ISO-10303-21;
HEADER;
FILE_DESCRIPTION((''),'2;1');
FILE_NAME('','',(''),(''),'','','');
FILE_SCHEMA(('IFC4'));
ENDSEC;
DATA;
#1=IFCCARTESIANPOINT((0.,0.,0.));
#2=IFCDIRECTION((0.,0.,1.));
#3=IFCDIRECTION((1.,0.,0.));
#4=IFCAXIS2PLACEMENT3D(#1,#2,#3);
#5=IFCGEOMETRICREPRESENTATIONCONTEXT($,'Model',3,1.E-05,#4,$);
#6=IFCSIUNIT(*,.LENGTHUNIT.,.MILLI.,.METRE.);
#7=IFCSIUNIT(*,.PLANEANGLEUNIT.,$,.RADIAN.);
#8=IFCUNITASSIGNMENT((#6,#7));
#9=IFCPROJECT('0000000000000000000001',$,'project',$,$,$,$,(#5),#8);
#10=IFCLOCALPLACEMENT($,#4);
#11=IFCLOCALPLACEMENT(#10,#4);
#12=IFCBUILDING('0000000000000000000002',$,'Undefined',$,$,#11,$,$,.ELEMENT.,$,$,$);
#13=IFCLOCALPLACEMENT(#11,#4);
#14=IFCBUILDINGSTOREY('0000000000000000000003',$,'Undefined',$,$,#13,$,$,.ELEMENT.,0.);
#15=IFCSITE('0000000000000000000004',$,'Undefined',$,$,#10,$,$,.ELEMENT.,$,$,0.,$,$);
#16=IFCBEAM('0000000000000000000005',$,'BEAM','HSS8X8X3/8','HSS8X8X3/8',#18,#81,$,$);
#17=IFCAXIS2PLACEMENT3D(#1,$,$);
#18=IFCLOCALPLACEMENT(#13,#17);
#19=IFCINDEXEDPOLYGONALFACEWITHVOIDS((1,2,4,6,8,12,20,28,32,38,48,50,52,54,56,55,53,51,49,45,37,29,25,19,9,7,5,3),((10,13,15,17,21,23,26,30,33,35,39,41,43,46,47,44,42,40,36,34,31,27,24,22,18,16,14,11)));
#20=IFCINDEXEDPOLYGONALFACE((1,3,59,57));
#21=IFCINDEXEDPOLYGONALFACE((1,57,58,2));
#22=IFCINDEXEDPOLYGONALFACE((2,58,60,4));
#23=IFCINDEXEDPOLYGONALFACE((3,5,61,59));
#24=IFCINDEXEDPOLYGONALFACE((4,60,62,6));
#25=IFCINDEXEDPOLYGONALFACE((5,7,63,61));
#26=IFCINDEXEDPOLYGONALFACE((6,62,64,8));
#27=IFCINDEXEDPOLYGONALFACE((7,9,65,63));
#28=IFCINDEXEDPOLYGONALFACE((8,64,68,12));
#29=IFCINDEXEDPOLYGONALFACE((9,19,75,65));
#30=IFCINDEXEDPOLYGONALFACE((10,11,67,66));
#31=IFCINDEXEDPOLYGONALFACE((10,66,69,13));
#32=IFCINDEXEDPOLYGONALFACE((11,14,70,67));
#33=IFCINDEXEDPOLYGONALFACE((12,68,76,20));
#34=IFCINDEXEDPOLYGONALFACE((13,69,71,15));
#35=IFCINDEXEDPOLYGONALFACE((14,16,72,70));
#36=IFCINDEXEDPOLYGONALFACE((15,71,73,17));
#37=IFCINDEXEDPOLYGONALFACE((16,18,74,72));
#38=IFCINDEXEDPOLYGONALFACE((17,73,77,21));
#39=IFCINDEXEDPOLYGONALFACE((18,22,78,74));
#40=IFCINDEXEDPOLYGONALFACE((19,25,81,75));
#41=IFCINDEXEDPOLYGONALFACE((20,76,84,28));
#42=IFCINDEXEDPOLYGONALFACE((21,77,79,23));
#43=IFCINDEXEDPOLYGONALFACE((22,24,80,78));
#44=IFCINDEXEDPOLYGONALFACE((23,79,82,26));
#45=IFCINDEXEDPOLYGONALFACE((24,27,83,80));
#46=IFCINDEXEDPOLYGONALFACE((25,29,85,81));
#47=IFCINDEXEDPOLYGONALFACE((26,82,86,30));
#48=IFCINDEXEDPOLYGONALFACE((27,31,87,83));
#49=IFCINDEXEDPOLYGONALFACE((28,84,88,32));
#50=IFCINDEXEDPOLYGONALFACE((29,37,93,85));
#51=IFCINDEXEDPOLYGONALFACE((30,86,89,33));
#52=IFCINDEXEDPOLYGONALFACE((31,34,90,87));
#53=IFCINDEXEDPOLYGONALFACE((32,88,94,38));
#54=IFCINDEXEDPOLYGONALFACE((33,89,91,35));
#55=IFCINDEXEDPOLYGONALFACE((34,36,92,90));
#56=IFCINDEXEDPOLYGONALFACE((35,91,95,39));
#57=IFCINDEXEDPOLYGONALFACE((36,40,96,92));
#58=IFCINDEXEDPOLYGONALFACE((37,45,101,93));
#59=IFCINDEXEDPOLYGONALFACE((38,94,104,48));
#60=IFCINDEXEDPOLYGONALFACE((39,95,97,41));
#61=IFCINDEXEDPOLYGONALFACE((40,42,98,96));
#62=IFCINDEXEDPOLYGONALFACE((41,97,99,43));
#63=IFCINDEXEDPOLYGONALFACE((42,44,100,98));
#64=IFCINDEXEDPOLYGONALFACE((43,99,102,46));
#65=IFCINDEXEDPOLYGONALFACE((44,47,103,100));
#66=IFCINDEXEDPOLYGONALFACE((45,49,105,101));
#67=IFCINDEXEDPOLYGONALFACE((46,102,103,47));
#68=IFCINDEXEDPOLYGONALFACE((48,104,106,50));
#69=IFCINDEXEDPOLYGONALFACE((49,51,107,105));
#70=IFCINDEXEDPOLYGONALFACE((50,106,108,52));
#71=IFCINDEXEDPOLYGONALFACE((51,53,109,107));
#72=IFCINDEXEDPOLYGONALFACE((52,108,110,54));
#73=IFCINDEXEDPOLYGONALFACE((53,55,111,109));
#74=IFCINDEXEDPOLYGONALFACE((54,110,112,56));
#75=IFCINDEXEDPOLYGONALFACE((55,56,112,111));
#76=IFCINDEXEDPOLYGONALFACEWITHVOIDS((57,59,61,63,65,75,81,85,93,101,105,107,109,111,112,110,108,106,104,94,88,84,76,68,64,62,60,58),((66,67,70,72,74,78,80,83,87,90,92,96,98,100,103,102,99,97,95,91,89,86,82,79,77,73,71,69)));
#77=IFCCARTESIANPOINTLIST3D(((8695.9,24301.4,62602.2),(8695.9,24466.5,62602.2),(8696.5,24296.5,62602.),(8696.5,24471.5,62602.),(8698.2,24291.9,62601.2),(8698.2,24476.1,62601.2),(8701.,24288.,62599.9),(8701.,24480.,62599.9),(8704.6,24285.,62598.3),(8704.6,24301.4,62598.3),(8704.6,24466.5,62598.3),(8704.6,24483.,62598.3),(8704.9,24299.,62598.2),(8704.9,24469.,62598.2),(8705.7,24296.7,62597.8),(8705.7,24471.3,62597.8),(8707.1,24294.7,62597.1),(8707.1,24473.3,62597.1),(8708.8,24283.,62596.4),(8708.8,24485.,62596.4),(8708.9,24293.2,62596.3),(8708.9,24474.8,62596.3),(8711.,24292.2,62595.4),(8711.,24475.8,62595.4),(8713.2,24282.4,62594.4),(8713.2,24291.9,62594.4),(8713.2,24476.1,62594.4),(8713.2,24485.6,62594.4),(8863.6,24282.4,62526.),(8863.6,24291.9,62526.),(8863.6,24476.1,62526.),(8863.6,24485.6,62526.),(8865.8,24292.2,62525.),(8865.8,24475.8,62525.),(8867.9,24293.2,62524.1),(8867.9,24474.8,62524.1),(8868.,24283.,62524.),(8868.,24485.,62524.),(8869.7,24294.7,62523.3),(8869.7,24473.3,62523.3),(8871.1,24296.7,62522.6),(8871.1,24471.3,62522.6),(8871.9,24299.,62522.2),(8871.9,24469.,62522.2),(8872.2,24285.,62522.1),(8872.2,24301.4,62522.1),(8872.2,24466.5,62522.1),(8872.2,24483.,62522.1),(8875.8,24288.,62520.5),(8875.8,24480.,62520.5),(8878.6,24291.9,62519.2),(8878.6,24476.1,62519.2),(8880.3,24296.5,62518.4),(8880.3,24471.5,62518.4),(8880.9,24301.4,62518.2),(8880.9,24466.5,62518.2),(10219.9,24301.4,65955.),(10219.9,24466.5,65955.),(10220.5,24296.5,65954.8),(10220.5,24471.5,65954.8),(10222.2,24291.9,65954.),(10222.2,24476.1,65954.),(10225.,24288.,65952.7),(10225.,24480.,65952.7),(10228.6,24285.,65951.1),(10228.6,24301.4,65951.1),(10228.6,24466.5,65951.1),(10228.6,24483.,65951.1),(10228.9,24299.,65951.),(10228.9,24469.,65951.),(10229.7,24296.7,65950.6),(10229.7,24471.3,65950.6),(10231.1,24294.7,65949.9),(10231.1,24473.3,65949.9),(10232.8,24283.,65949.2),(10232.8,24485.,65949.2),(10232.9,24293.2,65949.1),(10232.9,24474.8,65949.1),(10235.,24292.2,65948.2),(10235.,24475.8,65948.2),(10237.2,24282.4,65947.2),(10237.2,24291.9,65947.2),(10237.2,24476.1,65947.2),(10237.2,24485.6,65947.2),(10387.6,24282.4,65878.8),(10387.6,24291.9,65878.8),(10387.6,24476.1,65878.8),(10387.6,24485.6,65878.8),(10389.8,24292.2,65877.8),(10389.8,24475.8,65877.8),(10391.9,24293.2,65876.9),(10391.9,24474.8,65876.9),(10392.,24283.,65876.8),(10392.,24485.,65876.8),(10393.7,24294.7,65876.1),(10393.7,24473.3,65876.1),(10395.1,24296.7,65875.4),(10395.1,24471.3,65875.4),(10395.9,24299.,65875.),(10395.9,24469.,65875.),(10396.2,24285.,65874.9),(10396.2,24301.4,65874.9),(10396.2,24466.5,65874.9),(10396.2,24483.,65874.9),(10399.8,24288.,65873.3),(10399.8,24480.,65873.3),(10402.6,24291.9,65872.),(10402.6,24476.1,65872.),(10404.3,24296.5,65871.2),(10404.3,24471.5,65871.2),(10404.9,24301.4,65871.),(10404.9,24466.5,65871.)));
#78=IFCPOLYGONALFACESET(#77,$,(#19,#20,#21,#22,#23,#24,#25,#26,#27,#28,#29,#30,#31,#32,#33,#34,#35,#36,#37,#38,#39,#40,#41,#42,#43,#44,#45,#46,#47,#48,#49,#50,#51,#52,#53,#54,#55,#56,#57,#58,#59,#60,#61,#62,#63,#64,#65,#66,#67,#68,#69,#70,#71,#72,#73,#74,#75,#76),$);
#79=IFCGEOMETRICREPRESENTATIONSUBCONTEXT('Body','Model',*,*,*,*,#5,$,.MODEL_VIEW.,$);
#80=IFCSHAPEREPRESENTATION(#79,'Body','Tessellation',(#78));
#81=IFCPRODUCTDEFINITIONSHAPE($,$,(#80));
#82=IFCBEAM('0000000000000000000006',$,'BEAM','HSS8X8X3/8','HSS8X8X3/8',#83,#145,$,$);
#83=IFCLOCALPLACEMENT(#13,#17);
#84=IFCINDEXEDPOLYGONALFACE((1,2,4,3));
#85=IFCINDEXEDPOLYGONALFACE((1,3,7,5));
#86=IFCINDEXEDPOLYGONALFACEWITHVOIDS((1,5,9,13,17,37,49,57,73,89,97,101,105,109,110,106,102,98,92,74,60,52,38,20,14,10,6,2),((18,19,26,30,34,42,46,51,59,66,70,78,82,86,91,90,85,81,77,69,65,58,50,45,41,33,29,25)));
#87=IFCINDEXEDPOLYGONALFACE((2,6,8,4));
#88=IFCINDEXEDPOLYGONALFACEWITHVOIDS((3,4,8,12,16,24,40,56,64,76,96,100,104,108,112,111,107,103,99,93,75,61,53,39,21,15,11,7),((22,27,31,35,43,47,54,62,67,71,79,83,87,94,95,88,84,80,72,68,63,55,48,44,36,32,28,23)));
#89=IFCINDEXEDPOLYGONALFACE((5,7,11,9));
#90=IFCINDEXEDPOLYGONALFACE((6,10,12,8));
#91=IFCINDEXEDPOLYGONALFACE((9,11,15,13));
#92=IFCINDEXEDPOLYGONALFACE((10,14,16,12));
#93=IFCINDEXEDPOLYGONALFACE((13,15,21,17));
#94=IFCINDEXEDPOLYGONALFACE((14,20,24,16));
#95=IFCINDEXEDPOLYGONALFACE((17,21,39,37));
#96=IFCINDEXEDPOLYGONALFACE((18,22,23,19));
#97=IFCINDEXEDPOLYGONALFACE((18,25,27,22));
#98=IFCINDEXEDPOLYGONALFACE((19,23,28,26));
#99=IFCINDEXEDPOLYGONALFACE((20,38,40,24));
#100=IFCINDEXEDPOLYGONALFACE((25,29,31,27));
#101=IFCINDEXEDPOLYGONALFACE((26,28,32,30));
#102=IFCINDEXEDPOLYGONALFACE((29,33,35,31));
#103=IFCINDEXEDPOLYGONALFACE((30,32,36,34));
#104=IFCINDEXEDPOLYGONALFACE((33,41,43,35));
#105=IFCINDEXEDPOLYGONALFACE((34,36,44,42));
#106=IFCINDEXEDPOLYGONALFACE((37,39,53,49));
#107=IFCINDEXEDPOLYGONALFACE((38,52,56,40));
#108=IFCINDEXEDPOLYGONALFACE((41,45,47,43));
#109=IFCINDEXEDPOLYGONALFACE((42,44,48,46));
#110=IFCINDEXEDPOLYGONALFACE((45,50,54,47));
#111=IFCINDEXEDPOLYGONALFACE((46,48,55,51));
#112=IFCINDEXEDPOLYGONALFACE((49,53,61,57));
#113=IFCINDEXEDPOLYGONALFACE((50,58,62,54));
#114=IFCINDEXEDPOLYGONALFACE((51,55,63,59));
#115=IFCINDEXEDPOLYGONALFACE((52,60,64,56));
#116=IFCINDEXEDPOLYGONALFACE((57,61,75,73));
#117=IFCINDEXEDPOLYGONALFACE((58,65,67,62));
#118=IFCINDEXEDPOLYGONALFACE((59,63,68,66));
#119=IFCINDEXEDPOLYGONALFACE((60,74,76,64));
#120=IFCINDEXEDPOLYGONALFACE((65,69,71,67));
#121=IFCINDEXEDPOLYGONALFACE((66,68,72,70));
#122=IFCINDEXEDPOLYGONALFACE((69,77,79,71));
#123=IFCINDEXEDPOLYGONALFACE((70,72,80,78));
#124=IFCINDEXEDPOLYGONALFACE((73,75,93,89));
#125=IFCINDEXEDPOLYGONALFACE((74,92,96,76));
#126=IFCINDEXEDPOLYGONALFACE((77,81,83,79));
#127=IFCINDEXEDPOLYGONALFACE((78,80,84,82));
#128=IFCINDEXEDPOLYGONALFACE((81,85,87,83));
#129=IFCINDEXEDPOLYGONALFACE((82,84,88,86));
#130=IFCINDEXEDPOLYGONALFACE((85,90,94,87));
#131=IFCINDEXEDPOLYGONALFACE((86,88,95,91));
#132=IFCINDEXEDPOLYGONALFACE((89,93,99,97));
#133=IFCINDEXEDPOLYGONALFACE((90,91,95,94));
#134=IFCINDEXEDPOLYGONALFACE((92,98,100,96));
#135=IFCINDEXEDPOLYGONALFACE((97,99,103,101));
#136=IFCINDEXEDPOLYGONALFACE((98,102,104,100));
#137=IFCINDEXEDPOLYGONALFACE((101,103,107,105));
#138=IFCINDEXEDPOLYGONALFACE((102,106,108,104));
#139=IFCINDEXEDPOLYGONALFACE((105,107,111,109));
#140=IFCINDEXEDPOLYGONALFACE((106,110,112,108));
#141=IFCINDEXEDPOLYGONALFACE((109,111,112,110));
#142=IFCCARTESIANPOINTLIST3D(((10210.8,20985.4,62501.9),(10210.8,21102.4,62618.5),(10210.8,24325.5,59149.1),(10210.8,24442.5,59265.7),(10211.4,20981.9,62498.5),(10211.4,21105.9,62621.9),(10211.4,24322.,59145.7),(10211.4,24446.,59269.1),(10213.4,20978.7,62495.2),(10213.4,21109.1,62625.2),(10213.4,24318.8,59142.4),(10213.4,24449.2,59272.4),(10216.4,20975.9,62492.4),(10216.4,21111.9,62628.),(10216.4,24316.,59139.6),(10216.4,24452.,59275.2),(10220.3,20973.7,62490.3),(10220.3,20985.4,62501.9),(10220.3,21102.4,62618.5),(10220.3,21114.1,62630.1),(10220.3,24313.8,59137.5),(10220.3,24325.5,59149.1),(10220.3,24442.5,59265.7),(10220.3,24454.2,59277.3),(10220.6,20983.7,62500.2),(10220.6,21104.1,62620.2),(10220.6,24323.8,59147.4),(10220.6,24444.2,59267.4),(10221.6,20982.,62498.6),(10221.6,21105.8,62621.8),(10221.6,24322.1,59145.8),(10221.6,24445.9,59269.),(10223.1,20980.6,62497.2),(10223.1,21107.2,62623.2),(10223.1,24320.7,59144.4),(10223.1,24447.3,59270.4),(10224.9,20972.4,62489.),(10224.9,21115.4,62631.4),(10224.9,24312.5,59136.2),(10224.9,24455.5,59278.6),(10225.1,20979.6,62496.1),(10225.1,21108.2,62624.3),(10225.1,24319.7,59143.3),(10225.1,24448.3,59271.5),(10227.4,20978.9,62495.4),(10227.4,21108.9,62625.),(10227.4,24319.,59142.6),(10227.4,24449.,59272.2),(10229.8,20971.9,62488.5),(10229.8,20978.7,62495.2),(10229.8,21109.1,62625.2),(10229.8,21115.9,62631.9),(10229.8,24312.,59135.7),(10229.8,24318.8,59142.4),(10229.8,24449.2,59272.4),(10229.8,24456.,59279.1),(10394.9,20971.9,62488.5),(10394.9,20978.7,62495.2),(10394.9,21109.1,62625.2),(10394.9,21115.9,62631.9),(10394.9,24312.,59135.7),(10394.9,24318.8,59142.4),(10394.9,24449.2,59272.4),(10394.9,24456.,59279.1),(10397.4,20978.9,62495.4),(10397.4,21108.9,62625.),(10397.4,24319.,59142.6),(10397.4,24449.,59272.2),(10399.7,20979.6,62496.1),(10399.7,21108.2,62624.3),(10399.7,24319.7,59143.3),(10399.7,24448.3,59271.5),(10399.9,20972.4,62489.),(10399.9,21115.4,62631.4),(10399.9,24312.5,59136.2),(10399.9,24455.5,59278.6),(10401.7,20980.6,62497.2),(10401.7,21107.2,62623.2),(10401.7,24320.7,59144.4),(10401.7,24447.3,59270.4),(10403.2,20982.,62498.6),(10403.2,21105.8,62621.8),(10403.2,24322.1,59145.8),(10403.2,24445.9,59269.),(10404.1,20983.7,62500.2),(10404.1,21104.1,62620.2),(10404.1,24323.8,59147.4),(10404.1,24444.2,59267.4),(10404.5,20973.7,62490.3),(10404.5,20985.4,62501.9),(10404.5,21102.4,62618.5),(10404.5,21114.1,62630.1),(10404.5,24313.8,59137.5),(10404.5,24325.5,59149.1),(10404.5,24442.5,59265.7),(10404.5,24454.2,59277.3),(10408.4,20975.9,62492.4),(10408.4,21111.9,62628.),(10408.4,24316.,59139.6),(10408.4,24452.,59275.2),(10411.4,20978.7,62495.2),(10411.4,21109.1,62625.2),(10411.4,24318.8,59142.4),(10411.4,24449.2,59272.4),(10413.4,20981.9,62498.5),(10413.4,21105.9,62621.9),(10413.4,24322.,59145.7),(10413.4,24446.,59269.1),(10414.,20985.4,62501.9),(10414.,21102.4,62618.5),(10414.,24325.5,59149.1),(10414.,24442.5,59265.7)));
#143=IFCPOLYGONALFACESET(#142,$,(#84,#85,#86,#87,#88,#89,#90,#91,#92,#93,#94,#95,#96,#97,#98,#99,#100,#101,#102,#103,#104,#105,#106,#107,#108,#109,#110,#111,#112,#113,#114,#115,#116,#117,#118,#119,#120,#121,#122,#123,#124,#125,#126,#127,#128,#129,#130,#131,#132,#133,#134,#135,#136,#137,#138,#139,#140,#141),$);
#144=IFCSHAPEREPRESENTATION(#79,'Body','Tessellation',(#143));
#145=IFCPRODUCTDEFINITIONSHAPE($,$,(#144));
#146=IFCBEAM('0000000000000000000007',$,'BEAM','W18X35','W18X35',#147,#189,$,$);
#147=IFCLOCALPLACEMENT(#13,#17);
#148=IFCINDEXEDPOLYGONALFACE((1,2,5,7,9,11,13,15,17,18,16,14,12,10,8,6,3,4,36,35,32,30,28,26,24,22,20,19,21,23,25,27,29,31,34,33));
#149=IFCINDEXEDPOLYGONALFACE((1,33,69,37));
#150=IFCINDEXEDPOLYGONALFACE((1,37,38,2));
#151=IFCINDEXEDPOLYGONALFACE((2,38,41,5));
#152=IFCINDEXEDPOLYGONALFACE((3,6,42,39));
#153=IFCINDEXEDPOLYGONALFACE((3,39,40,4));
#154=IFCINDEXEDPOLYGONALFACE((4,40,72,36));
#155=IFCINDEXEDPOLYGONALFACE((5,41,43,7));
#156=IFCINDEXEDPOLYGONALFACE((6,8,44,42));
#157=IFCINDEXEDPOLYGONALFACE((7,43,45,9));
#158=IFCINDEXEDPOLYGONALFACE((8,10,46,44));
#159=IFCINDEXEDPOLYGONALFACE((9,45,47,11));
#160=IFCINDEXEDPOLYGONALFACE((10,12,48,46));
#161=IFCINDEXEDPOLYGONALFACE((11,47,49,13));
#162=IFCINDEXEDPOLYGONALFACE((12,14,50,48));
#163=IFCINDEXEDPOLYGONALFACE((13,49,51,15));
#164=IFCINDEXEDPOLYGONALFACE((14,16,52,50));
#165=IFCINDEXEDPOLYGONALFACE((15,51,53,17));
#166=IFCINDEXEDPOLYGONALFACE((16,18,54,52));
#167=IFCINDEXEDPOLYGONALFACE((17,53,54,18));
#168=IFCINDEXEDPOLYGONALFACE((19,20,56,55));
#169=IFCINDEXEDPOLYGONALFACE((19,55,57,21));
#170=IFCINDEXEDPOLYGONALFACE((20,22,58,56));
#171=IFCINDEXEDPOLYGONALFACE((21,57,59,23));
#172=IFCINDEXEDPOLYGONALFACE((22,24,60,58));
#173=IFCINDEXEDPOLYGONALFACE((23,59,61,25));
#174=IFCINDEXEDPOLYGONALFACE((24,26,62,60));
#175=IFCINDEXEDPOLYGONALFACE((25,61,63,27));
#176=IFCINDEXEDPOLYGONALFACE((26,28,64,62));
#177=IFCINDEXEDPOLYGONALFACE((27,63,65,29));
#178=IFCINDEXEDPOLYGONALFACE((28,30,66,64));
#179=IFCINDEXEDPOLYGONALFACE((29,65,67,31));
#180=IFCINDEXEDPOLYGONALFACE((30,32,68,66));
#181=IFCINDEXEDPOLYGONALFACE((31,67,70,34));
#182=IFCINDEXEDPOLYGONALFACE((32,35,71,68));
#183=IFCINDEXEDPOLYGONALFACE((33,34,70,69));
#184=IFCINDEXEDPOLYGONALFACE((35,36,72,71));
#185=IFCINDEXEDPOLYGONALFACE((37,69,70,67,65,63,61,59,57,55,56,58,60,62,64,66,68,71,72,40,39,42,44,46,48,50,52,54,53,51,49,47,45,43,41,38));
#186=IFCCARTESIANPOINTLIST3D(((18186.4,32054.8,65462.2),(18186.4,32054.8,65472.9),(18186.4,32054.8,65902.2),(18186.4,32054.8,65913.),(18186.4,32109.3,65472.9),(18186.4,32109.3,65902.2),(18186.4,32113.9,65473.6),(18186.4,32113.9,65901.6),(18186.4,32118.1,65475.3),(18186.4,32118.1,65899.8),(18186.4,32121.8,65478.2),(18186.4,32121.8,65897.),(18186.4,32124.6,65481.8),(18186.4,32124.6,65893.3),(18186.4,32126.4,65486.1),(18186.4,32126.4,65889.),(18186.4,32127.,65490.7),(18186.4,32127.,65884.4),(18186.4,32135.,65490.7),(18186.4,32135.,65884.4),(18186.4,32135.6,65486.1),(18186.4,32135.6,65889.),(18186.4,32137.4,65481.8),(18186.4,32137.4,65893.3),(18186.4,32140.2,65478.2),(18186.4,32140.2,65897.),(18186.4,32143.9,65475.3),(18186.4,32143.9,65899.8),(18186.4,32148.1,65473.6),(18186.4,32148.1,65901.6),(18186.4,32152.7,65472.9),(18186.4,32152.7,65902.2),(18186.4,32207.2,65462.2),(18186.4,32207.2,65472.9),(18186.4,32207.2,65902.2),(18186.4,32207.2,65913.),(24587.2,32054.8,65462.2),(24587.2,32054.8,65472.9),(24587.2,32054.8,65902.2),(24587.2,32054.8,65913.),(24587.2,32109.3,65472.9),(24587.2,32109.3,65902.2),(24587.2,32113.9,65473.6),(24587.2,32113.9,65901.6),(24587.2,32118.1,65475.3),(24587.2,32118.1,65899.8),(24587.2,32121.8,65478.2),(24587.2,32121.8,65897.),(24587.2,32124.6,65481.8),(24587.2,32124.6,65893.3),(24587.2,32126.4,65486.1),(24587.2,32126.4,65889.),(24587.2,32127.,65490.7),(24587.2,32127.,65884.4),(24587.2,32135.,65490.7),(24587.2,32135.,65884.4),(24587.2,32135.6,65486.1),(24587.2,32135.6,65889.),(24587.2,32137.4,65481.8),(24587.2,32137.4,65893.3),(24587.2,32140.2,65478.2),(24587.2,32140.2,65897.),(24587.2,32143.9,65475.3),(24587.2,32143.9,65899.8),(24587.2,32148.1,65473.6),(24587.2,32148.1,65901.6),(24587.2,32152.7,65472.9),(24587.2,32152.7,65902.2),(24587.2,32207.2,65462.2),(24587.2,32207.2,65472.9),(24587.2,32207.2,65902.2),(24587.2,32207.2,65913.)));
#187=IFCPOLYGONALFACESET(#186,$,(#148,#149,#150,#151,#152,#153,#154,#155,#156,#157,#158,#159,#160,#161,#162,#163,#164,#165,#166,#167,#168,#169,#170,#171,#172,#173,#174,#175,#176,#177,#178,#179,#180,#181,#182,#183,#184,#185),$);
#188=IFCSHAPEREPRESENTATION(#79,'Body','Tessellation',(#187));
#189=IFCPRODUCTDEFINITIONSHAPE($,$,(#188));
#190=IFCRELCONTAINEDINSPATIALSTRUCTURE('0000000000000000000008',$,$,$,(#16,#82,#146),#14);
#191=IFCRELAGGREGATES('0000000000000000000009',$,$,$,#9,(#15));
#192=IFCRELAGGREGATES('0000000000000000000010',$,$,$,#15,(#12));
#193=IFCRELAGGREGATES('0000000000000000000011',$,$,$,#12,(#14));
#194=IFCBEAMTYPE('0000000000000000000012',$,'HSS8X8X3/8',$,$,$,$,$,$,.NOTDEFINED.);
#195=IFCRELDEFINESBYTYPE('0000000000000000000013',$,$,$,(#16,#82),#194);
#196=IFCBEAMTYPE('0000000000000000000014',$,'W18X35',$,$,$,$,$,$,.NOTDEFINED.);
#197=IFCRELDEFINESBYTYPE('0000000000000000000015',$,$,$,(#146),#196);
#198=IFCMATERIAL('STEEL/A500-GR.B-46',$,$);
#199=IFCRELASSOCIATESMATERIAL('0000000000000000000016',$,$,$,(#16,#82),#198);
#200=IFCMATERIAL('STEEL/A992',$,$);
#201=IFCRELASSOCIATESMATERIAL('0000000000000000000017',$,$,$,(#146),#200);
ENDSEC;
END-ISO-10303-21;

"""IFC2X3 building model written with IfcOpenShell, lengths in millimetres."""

from ifc_helpers import new_model, si_unit, frame, origin_with_axes, origin_2d_with_axis, place, context, subcontext, project, spatial, hollow_rectangle, i_section, extrude, material, type_object, element, save


model = new_model("IFC2X3")

# Units and contexts
model_context = context("Model", 3, precision=1e-05, world=origin_with_axes())
body_context = subcontext(model_context, "Body", "Model", "MODEL_VIEW")
ifc_project = project(units=[si_unit("LENGTHUNIT", "METRE", prefix="MILLI"), si_unit("PLANEANGLEUNIT", "RADIAN")], contexts=[model_context])

# Site, building, storey
site_placement = place(None, origin_with_axes())
site = spatial("IfcSite", under=ifc_project, at=site_placement, Name="Undefined", CompositionType="ELEMENT", RefElevation=0.0)
building_placement = place(site_placement, origin_with_axes())
building = spatial("IfcBuilding", under=site, at=building_placement, Name="Undefined", CompositionType="ELEMENT")
storey_placement = place(building_placement, origin_with_axes())
storey = spatial("IfcBuildingStorey", under=building, at=storey_placement, Name="Undefined", CompositionType="ELEMENT", Elevation=0.0)

# Shared definitions
ifc_material_1 = material(Name="STEEL/A992")

# Beams
ifc_material_2 = material(Name="STEEL/A500-GR.B-46")
beam_type_1 = type_object("IfcBeamType", Name="HSS8X8X3/8", PredefinedType="NOTDEFINED")
beam_1_placement = place(storey_placement, frame((8788.4, 24384.0, 62560.2), z_axis=(-0.910367, 0.0, 0.413803), x_axis=(0.413803, 0.0, 0.910367)))
element("IfcBeam", 1, at=beam_1_placement, inside=storey, type_object=beam_type_1, material=ifc_material_2, Name="BEAM", Description="HSS8X8X3/8", ObjectType="HSS8X8X3/8", context=body_context, shape_type="SweptSolid", body=[
    extrude(hollow_rectangle(XDim=203.2, YDim=203.2, WallThickness=9.5, InnerFilletRadius=9.5, OuterFilletRadius=19.0, at=origin_2d_with_axis()), frame((3682.9, 0.0, 0.0), z_axis=(-1.0, 0.0, 0.0), x_axis=(0.0, -1.0, 0.0)), (0.0, 0.0, 1.0), 3682.9),
])
beam_2_placement = place(storey_placement, frame((10312.4, 24384.0, 59207.4), z_axis=(0.0, 0.708447, 0.705764), x_axis=(0.0, -0.705764, 0.708447)))
element("IfcBeam", 2, at=beam_2_placement, inside=storey, type_object=beam_type_1, material=ifc_material_2, Name="BEAM", Description="HSS8X8X3/8", ObjectType="HSS8X8X3/8", context=body_context, shape_type="SweptSolid", body=[
    extrude(hollow_rectangle(XDim=203.2, YDim=203.2, WallThickness=9.5, InnerFilletRadius=9.5, OuterFilletRadius=19.0, at=origin_2d_with_axis()), frame((4732.6, 0.0, 0.0), z_axis=(-1.0, 0.0, 0.0), x_axis=(0.0, -1.0, 0.0)), (0.0, 0.0, 1.0), 4732.6),
])
beam_type_2 = type_object("IfcBeamType", Name="W18X35", PredefinedType="NOTDEFINED")
for number, where, z_axis, x_axis, name in (
    (3, (18186.4, 32131.0, 65687.6), (0.0, 0.0, 1.0), (1.0, 0.0, 0.0), "BEAM"),
):
    element("IfcBeam", number, at=place(storey_placement, frame(where, z_axis=z_axis, x_axis=x_axis)), inside=storey, type_object=beam_type_2, material=ifc_material_1, Name=name, Description="W18X35", ObjectType="W18X35", context=body_context, shape_type="SweptSolid", body=[
        extrude(i_section(OverallWidth=152.4, OverallDepth=450.9, WebThickness=7.9, FlangeThickness=10.8, FilletRadius=17.8, at=origin_2d_with_axis()), frame((6400.8, 0.0, 0.0), z_axis=(-1.0, 0.0, 0.0), x_axis=(0.0, -1.0, 0.0)), (0.0, 0.0, 1.0), 6400.8),
    ])

save(model, "model.ifc")
